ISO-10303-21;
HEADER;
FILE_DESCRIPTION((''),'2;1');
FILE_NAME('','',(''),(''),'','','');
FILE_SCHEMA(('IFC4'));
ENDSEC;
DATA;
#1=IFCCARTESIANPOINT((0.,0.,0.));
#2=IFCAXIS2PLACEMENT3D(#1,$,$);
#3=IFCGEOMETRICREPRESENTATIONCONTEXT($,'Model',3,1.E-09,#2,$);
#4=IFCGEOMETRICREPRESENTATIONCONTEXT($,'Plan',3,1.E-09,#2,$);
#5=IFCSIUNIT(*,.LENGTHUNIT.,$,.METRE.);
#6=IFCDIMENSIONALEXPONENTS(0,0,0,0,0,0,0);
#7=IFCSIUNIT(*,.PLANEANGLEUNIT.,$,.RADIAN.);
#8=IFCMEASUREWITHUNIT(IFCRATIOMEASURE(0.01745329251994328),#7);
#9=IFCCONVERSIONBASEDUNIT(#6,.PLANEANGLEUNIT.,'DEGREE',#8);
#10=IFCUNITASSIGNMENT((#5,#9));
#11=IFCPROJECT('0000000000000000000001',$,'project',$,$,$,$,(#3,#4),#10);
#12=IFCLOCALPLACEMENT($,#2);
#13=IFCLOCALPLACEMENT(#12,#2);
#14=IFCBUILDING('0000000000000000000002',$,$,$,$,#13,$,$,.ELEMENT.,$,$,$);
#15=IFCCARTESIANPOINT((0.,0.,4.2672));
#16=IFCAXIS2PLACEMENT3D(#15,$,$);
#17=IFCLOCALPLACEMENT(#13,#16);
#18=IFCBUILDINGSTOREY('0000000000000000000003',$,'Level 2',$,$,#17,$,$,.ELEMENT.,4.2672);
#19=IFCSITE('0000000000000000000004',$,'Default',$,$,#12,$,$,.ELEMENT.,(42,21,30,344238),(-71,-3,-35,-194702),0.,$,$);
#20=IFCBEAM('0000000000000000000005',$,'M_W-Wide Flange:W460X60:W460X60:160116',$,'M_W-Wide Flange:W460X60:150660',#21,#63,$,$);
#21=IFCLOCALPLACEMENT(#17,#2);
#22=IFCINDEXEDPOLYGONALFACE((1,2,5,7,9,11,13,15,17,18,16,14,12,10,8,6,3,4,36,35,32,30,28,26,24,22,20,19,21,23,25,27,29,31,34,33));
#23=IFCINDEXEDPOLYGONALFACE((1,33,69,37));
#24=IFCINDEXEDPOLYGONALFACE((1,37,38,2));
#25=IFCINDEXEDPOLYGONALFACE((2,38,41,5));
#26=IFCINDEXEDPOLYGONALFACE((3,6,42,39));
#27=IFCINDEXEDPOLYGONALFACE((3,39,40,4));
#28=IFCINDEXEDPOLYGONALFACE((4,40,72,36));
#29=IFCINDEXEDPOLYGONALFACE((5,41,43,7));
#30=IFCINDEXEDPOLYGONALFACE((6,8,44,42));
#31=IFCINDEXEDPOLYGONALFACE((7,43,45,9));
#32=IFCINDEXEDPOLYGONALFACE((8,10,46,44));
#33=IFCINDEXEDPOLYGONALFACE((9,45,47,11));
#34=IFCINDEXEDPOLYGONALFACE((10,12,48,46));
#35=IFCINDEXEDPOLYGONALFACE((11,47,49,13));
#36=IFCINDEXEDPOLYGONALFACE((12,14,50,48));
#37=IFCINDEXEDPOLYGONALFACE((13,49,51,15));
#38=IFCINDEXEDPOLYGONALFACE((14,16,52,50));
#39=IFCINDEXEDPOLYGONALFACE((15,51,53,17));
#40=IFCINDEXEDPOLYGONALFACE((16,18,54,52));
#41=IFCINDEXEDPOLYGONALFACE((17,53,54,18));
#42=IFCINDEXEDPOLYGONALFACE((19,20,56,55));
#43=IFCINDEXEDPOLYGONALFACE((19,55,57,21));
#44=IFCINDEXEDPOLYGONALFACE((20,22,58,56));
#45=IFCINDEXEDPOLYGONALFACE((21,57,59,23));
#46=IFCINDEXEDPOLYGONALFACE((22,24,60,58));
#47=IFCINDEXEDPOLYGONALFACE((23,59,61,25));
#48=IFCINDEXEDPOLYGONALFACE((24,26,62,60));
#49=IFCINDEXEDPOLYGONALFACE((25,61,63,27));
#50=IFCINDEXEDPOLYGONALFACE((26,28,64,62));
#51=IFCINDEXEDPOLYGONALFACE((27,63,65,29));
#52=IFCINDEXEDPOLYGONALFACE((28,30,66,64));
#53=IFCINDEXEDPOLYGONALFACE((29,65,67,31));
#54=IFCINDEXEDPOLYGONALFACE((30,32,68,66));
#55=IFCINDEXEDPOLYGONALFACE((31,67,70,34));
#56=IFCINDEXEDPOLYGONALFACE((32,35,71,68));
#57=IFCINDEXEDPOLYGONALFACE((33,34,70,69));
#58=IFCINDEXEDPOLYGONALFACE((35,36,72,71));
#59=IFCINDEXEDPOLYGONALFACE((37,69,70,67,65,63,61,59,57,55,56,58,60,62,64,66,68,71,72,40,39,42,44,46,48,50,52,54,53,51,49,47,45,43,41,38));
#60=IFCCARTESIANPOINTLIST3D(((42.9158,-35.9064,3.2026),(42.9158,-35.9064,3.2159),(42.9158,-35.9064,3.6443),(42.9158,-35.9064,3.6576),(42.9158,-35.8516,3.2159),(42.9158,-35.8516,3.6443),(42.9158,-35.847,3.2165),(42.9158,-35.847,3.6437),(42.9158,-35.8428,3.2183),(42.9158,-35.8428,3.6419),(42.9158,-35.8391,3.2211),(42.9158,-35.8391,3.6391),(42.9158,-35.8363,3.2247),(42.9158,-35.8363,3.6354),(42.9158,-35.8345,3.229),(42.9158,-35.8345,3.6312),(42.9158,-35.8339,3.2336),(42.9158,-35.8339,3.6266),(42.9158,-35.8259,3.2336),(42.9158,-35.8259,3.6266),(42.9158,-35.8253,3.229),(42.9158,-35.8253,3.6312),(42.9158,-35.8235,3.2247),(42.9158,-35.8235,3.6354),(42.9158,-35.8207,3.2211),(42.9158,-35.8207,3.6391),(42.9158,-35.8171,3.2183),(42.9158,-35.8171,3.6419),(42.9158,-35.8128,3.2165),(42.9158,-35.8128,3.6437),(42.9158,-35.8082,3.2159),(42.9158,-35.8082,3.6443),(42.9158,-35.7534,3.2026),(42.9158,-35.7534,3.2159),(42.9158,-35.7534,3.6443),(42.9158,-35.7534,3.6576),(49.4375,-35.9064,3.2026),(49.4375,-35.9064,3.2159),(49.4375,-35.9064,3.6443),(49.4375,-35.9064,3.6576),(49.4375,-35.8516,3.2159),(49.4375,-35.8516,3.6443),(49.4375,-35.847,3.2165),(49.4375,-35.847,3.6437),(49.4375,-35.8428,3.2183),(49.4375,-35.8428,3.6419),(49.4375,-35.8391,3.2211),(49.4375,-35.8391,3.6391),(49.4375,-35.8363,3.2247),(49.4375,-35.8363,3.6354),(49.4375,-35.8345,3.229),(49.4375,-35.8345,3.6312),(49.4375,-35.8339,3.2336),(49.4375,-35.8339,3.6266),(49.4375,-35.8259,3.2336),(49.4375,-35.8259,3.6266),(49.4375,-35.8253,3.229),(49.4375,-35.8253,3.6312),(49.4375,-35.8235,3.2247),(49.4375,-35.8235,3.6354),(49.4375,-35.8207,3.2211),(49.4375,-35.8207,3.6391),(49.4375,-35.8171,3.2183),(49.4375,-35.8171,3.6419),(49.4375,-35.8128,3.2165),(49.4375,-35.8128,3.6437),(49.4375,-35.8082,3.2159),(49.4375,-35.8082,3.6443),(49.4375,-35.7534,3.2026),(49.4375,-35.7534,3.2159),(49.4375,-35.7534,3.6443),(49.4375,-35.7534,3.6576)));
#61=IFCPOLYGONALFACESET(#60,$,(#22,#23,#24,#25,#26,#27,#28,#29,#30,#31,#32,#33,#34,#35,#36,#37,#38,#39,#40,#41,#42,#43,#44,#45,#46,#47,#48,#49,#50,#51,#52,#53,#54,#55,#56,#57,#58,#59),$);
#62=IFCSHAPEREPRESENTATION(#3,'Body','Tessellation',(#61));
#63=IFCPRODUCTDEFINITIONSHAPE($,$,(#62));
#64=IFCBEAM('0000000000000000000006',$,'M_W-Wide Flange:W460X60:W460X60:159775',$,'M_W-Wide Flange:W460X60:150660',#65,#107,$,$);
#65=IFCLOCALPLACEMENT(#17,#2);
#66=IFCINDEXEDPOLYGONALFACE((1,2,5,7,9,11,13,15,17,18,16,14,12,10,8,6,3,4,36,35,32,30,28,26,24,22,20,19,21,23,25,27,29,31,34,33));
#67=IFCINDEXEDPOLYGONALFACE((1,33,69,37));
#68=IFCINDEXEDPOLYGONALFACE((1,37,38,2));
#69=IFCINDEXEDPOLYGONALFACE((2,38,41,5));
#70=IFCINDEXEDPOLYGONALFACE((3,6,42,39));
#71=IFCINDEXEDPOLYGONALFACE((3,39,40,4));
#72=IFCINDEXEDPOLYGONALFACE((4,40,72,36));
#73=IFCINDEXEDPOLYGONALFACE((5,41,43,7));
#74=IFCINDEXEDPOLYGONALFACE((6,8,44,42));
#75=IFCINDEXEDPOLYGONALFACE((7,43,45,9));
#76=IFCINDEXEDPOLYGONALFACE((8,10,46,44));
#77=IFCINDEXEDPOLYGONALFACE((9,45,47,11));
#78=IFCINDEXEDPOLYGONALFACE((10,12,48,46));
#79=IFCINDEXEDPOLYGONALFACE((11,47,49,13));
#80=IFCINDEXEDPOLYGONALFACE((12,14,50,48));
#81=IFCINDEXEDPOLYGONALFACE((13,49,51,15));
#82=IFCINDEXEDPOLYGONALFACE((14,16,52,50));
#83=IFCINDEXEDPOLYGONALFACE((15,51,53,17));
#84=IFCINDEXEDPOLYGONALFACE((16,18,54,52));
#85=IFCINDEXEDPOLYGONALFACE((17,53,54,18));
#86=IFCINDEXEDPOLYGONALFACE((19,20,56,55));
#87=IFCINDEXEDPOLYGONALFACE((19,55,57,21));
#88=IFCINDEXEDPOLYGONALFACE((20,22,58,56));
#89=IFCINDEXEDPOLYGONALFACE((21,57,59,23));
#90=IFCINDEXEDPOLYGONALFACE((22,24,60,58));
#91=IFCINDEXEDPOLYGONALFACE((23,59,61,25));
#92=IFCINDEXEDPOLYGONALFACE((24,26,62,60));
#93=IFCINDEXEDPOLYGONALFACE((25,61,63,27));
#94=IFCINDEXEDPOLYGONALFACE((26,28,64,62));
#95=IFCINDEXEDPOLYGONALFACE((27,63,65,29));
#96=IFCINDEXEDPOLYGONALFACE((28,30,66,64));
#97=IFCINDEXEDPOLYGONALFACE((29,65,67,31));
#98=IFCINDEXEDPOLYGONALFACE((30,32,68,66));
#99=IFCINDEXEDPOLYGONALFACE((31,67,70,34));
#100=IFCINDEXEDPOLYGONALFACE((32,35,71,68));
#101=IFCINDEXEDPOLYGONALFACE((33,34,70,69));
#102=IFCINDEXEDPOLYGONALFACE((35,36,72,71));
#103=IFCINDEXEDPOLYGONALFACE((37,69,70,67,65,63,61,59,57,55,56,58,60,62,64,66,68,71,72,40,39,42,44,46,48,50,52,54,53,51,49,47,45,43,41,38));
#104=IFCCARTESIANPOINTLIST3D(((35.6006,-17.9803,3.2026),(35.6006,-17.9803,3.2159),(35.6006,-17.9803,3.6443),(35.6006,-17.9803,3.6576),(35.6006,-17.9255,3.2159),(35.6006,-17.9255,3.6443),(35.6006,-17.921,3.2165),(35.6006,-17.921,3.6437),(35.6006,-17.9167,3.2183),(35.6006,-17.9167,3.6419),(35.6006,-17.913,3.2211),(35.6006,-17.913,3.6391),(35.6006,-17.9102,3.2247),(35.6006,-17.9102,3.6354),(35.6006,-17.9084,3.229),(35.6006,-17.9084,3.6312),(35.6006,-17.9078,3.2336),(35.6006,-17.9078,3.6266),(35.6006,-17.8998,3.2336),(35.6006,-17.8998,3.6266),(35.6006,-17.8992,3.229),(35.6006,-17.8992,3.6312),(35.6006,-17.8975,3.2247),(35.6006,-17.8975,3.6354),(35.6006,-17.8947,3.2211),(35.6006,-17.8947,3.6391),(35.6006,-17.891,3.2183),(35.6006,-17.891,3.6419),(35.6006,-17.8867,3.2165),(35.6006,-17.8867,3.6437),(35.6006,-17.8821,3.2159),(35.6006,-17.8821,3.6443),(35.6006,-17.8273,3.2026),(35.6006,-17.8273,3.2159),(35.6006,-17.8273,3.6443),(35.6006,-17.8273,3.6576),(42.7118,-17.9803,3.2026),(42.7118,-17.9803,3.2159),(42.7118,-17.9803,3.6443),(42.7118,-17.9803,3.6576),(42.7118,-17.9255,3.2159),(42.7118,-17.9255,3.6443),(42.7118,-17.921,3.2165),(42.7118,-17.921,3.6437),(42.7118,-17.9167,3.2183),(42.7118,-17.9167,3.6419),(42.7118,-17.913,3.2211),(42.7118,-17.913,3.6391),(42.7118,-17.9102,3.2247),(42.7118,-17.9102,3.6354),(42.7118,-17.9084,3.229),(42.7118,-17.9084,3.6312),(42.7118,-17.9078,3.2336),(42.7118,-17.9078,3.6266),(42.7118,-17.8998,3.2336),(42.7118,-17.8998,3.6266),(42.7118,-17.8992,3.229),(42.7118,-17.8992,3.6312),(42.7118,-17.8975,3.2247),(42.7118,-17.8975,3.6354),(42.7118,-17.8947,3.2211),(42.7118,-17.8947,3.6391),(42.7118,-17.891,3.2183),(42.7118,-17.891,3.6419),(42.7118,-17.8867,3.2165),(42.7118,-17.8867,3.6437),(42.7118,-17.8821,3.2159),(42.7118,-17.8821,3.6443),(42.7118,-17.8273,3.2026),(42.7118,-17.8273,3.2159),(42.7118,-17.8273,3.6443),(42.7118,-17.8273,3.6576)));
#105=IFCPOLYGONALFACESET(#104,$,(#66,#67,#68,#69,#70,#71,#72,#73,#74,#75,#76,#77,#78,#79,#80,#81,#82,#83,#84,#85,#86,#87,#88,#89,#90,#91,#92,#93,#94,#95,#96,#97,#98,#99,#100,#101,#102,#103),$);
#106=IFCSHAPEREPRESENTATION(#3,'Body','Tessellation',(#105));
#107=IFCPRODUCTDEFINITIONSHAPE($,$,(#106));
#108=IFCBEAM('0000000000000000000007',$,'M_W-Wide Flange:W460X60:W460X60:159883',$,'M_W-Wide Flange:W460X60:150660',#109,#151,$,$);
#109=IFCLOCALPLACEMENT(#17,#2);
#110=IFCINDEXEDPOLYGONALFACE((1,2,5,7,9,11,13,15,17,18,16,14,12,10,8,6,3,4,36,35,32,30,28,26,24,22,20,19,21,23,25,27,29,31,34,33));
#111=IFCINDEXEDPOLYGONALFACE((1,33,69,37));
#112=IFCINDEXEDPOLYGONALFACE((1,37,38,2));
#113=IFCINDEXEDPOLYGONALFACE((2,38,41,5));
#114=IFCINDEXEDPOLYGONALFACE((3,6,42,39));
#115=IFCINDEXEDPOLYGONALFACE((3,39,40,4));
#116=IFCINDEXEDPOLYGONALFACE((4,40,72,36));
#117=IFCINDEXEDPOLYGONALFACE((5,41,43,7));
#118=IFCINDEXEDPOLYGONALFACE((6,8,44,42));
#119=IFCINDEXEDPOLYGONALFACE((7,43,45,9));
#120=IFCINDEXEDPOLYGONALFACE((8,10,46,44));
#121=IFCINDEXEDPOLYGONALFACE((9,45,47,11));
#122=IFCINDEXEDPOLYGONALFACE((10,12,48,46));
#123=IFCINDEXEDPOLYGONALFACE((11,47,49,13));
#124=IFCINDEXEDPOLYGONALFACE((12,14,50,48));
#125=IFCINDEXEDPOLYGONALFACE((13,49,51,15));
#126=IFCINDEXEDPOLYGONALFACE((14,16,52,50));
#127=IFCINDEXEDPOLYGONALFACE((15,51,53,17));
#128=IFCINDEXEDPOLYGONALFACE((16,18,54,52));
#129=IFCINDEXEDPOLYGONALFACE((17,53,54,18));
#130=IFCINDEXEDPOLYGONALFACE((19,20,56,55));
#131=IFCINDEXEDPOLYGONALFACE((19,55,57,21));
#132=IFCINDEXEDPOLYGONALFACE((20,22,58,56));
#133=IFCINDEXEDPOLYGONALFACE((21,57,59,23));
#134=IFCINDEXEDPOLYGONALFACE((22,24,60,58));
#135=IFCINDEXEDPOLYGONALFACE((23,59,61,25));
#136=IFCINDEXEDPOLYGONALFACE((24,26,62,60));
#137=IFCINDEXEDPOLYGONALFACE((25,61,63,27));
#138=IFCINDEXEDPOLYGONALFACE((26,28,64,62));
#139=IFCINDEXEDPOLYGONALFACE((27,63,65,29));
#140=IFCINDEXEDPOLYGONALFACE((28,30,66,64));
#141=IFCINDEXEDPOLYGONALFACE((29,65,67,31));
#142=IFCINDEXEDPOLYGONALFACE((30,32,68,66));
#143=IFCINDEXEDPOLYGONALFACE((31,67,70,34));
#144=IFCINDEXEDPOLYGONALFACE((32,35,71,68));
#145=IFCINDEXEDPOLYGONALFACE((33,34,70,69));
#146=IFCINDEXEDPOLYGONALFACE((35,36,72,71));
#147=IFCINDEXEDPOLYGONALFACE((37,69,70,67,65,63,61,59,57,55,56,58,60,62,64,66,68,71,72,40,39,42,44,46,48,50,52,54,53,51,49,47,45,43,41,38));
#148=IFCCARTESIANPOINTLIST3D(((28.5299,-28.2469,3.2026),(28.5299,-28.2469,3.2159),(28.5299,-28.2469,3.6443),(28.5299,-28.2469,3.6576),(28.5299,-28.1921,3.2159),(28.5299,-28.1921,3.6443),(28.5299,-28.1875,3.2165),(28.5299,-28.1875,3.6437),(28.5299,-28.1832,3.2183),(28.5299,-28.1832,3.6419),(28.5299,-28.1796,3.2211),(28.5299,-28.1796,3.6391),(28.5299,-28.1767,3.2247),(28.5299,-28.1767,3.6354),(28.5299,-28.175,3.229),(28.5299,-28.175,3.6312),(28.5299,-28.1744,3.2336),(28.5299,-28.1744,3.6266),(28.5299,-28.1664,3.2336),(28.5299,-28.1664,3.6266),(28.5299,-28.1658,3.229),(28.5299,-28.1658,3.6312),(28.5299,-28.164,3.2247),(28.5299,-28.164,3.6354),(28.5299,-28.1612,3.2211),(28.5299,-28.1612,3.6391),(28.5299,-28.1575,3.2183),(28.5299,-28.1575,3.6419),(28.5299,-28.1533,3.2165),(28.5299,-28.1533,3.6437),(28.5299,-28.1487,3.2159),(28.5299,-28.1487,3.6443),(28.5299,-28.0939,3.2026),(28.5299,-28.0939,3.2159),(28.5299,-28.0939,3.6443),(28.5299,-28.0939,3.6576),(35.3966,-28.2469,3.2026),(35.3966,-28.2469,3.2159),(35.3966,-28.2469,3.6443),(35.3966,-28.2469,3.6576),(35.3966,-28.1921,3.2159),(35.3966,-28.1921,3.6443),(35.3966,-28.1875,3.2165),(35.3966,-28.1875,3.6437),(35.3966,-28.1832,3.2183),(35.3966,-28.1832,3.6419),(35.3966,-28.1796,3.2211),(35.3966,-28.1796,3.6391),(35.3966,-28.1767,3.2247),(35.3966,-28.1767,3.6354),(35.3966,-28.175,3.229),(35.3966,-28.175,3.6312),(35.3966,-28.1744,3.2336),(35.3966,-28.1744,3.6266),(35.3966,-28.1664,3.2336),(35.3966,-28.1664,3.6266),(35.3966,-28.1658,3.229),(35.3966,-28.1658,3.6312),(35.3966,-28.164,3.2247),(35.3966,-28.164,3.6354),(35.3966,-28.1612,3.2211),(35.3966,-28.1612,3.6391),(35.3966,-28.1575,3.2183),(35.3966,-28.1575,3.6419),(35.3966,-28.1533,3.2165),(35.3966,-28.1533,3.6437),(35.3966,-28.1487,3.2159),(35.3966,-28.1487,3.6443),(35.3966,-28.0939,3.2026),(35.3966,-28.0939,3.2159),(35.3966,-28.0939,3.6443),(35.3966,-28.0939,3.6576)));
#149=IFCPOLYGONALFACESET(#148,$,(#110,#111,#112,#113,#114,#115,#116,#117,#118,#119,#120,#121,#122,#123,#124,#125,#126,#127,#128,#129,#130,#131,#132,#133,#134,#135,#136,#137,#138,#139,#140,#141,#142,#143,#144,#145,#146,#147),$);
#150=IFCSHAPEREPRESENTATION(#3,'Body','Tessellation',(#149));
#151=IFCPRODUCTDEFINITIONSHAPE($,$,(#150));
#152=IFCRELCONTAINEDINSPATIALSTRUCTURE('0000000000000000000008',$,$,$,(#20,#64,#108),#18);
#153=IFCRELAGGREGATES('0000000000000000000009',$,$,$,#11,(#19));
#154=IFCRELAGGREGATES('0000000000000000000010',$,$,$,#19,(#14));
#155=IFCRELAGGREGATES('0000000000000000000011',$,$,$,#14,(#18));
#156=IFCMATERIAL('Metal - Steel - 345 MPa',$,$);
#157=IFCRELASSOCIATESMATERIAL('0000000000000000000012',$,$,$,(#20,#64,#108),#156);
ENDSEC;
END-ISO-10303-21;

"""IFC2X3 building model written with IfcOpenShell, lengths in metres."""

from ifc_helpers import new_model, entity, si_unit, converted_unit, frame, frame_2d, origin, place, context, project, spatial, polyline, circle_curve, parameter, trimmed, segment, composite_curve, outline, extrude, material, element, save


model = new_model("IFC2X3")

# Units and contexts
model_context = context("Model", 3, precision=1e-09, world=origin())
plan_context = context("Plan", 3, precision=1e-09, world=origin())
ifc_project = project(units=[si_unit("LENGTHUNIT", "METRE"), converted_unit("PLANEANGLEUNIT", "DEGREE", entity("IfcRatioMeasure", 0.01745329251994328), si_unit("PLANEANGLEUNIT", "RADIAN"), dimensions=[0, 0, 0, 0, 0, 0, 0])], contexts=[model_context, plan_context])

# Site, building, storey
site_placement = place(None, origin())
site = spatial("IfcSite", under=ifc_project, at=site_placement, Name="Default", CompositionType="ELEMENT", RefLatitude=(42, 21, 30, 344238), RefLongitude=(-71, -3, -35, -194702), RefElevation=0.0)
building_placement = place(site_placement, origin())
building = spatial("IfcBuilding", under=site, at=building_placement, CompositionType="ELEMENT")
storey_placement = place(building_placement, frame((0.0, 0.0, 4.2672)))
storey = spatial("IfcBuildingStorey", under=building, at=storey_placement, Name="Level 2", CompositionType="ELEMENT", Elevation=4.2672)

# Shared definitions
ifc_material = material(Name="Metal - Steel - 345 MPa")

# Beams
beam_1_placement = place(storey_placement, frame((42.8138, -35.8299, 3.6576), z_axis=(0.0, 0.0, 1.0), x_axis=(0.0, -1.0, 0.0)))
element("IfcBeam", 1, at=beam_1_placement, inside=storey, material=ifc_material, Name="M_W-Wide Flange:W460X60:W460X60:160116", ObjectType="M_W-Wide Flange:W460X60:150660", context=model_context, shape_type="SweptSolid", body=[
    extrude(outline(composite_curve([segment(polyline([(-0.0765, -0.2142), (-0.0765, -0.2275)]), True, "CONTINUOUS"), segment(polyline([(-0.0765, -0.2275), (0.0765, -0.2275)]), True, "CONTINUOUS"), segment(polyline([(0.0765, -0.2275), (0.0765, -0.2142)]), True, "CONTINUOUS"), segment(polyline([(0.0765, -0.2142), (0.0217, -0.2142)]), True, "CONTINUOUS"), segment(trimmed(circle_curve(frame_2d((0.0217, -0.1965), x_axis=(0.0, -1.0)), 0.0177), [parameter(270.0)], [parameter(360.0)], True, "PARAMETER"), False, "CONTINUOUS"), segment(polyline([(0.004, -0.1965), (0.004, 0.1965)]), True, "CONTINUOUS"), segment(trimmed(circle_curve(frame_2d((0.0217, 0.1965), x_axis=(-1.0, 0.0)), 0.0177), [parameter(270.0)], [parameter(360.0)], True, "PARAMETER"), False, "CONTINUOUS"), segment(polyline([(0.0217, 0.2142), (0.0765, 0.2142)]), True, "CONTINUOUS"), segment(polyline([(0.0765, 0.2142), (0.0765, 0.2275)]), True, "CONTINUOUS"), segment(polyline([(0.0765, 0.2275), (-0.0765, 0.2275)]), True, "CONTINUOUS"), segment(polyline([(-0.0765, 0.2275), (-0.0765, 0.2142)]), True, "CONTINUOUS"), segment(polyline([(-0.0765, 0.2142), (-0.0217, 0.2142)]), True, "CONTINUOUS"), segment(trimmed(circle_curve(frame_2d((-0.0217, 0.1965), x_axis=(0.0, 1.0)), 0.0177), [parameter(270.0)], [parameter(360.0)], True, "PARAMETER"), False, "CONTINUOUS"), segment(polyline([(-0.004, 0.1965), (-0.004, -0.1965)]), True, "CONTINUOUS"), segment(trimmed(circle_curve(frame_2d((-0.0217, -0.1965), x_axis=(1.0, 0.0)), 0.0177), [parameter(270.0)], [parameter(0.0)], True, "PARAMETER"), False, "CONTINUOUS"), segment(polyline([(-0.0217, -0.2142), (-0.0765, -0.2142)]), True, "CONTINUOUS")], self_intersect=False)), frame((0.0, 0.102, -0.2275), z_axis=(0.0, -1.0, 0.0), x_axis=(1.0, 0.0, 0.0)), (0.0, 0.0, -1.0), 6.5217),
])
beam_2_placement = place(storey_placement, frame((35.4986, -17.9038, 3.6576), z_axis=(0.0, 0.0, 1.0), x_axis=(0.0, -1.0, 0.0)))
element("IfcBeam", 2, at=beam_2_placement, inside=storey, material=ifc_material, Name="M_W-Wide Flange:W460X60:W460X60:159775", ObjectType="M_W-Wide Flange:W460X60:150660", context=model_context, shape_type="SweptSolid", body=[
    extrude(outline(composite_curve([segment(polyline([(-0.0765, -0.2142), (-0.0765, -0.2275)]), True, "CONTINUOUS"), segment(polyline([(-0.0765, -0.2275), (0.0765, -0.2275)]), True, "CONTINUOUS"), segment(polyline([(0.0765, -0.2275), (0.0765, -0.2142)]), True, "CONTINUOUS"), segment(polyline([(0.0765, -0.2142), (0.0217, -0.2142)]), True, "CONTINUOUS"), segment(trimmed(circle_curve(frame_2d((0.0217, -0.1965), x_axis=(0.0, -1.0)), 0.0177), [parameter(270.0)], [parameter(360.0)], True, "PARAMETER"), False, "CONTINUOUS"), segment(polyline([(0.004, -0.1965), (0.004, 0.1965)]), True, "CONTINUOUS"), segment(trimmed(circle_curve(frame_2d((0.0217, 0.1965), x_axis=(-1.0, 0.0)), 0.0177), [parameter(270.0)], [parameter(360.0)], True, "PARAMETER"), False, "CONTINUOUS"), segment(polyline([(0.0217, 0.2142), (0.0765, 0.2142)]), True, "CONTINUOUS"), segment(polyline([(0.0765, 0.2142), (0.0765, 0.2275)]), True, "CONTINUOUS"), segment(polyline([(0.0765, 0.2275), (-0.0765, 0.2275)]), True, "CONTINUOUS"), segment(polyline([(-0.0765, 0.2275), (-0.0765, 0.2142)]), True, "CONTINUOUS"), segment(polyline([(-0.0765, 0.2142), (-0.0217, 0.2142)]), True, "CONTINUOUS"), segment(trimmed(circle_curve(frame_2d((-0.0217, 0.1965), x_axis=(0.0, 1.0)), 0.0177), [parameter(270.0)], [parameter(360.0)], True, "PARAMETER"), False, "CONTINUOUS"), segment(polyline([(-0.004, 0.1965), (-0.004, -0.1965)]), True, "CONTINUOUS"), segment(trimmed(circle_curve(frame_2d((-0.0217, -0.1965), x_axis=(1.0, 0.0)), 0.0177), [parameter(270.0)], [parameter(0.0)], True, "PARAMETER"), False, "CONTINUOUS"), segment(polyline([(-0.0217, -0.2142), (-0.0765, -0.2142)]), True, "CONTINUOUS")], self_intersect=False)), frame((0.0, 0.102, -0.2275), z_axis=(0.0, -1.0, 0.0), x_axis=(1.0, 0.0, 0.0)), (0.0, 0.0, -1.0), 7.1112),
])
beam_3_placement = place(storey_placement, frame((35.4986, -28.1704, 3.6576), z_axis=(0.0, 0.0, 1.0), x_axis=(0.0, 1.0, 0.0)))
element("IfcBeam", 3, at=beam_3_placement, inside=storey, material=ifc_material, Name="M_W-Wide Flange:W460X60:W460X60:159883", ObjectType="M_W-Wide Flange:W460X60:150660", context=model_context, shape_type="SweptSolid", body=[
    extrude(outline(composite_curve([segment(polyline([(0.2142, -0.0765), (0.2275, -0.0765)]), True, "CONTINUOUS"), segment(polyline([(0.2275, -0.0765), (0.2275, 0.0765)]), True, "CONTINUOUS"), segment(polyline([(0.2275, 0.0765), (0.2142, 0.0765)]), True, "CONTINUOUS"), segment(polyline([(0.2142, 0.0765), (0.2142, 0.0217)]), True, "CONTINUOUS"), segment(trimmed(circle_curve(frame_2d((0.1965, 0.0217), x_axis=(1.0, 0.0)), 0.0177), [parameter(270.0)], [parameter(360.0)], True, "PARAMETER"), False, "CONTINUOUS"), segment(polyline([(0.1965, 0.004), (-0.1965, 0.004)]), True, "CONTINUOUS"), segment(trimmed(circle_curve(frame_2d((-0.1965, 0.0217), x_axis=(0.0, -1.0)), 0.0177), [parameter(270.0)], [parameter(360.0)], True, "PARAMETER"), False, "CONTINUOUS"), segment(polyline([(-0.2142, 0.0217), (-0.2142, 0.0765)]), True, "CONTINUOUS"), segment(polyline([(-0.2142, 0.0765), (-0.2275, 0.0765)]), True, "CONTINUOUS"), segment(polyline([(-0.2275, 0.0765), (-0.2275, -0.0765)]), True, "CONTINUOUS"), segment(polyline([(-0.2275, -0.0765), (-0.2142, -0.0765)]), True, "CONTINUOUS"), segment(polyline([(-0.2142, -0.0765), (-0.2142, -0.0217)]), True, "CONTINUOUS"), segment(trimmed(circle_curve(frame_2d((-0.1965, -0.0217), x_axis=(-1.0, 0.0)), 0.0177), [parameter(270.0)], [parameter(360.0)], True, "PARAMETER"), False, "CONTINUOUS"), segment(polyline([(-0.1965, -0.004), (0.1965, -0.004)]), True, "CONTINUOUS"), segment(trimmed(circle_curve(frame_2d((0.1965, -0.0217), x_axis=(0.0, 1.0)), 0.0177), [parameter(270.0)], [parameter(0.0)], True, "PARAMETER"), False, "CONTINUOUS"), segment(polyline([(0.2142, -0.0217), (0.2142, -0.0765)]), True, "CONTINUOUS")], self_intersect=False)), frame((0.0, 6.9688, -0.2275), z_axis=(0.0, -1.0, 0.0), x_axis=(0.0, 0.0, -1.0)), (0.0, 0.0, 1.0), 6.8668),
])

save(model, "model.ifc")
